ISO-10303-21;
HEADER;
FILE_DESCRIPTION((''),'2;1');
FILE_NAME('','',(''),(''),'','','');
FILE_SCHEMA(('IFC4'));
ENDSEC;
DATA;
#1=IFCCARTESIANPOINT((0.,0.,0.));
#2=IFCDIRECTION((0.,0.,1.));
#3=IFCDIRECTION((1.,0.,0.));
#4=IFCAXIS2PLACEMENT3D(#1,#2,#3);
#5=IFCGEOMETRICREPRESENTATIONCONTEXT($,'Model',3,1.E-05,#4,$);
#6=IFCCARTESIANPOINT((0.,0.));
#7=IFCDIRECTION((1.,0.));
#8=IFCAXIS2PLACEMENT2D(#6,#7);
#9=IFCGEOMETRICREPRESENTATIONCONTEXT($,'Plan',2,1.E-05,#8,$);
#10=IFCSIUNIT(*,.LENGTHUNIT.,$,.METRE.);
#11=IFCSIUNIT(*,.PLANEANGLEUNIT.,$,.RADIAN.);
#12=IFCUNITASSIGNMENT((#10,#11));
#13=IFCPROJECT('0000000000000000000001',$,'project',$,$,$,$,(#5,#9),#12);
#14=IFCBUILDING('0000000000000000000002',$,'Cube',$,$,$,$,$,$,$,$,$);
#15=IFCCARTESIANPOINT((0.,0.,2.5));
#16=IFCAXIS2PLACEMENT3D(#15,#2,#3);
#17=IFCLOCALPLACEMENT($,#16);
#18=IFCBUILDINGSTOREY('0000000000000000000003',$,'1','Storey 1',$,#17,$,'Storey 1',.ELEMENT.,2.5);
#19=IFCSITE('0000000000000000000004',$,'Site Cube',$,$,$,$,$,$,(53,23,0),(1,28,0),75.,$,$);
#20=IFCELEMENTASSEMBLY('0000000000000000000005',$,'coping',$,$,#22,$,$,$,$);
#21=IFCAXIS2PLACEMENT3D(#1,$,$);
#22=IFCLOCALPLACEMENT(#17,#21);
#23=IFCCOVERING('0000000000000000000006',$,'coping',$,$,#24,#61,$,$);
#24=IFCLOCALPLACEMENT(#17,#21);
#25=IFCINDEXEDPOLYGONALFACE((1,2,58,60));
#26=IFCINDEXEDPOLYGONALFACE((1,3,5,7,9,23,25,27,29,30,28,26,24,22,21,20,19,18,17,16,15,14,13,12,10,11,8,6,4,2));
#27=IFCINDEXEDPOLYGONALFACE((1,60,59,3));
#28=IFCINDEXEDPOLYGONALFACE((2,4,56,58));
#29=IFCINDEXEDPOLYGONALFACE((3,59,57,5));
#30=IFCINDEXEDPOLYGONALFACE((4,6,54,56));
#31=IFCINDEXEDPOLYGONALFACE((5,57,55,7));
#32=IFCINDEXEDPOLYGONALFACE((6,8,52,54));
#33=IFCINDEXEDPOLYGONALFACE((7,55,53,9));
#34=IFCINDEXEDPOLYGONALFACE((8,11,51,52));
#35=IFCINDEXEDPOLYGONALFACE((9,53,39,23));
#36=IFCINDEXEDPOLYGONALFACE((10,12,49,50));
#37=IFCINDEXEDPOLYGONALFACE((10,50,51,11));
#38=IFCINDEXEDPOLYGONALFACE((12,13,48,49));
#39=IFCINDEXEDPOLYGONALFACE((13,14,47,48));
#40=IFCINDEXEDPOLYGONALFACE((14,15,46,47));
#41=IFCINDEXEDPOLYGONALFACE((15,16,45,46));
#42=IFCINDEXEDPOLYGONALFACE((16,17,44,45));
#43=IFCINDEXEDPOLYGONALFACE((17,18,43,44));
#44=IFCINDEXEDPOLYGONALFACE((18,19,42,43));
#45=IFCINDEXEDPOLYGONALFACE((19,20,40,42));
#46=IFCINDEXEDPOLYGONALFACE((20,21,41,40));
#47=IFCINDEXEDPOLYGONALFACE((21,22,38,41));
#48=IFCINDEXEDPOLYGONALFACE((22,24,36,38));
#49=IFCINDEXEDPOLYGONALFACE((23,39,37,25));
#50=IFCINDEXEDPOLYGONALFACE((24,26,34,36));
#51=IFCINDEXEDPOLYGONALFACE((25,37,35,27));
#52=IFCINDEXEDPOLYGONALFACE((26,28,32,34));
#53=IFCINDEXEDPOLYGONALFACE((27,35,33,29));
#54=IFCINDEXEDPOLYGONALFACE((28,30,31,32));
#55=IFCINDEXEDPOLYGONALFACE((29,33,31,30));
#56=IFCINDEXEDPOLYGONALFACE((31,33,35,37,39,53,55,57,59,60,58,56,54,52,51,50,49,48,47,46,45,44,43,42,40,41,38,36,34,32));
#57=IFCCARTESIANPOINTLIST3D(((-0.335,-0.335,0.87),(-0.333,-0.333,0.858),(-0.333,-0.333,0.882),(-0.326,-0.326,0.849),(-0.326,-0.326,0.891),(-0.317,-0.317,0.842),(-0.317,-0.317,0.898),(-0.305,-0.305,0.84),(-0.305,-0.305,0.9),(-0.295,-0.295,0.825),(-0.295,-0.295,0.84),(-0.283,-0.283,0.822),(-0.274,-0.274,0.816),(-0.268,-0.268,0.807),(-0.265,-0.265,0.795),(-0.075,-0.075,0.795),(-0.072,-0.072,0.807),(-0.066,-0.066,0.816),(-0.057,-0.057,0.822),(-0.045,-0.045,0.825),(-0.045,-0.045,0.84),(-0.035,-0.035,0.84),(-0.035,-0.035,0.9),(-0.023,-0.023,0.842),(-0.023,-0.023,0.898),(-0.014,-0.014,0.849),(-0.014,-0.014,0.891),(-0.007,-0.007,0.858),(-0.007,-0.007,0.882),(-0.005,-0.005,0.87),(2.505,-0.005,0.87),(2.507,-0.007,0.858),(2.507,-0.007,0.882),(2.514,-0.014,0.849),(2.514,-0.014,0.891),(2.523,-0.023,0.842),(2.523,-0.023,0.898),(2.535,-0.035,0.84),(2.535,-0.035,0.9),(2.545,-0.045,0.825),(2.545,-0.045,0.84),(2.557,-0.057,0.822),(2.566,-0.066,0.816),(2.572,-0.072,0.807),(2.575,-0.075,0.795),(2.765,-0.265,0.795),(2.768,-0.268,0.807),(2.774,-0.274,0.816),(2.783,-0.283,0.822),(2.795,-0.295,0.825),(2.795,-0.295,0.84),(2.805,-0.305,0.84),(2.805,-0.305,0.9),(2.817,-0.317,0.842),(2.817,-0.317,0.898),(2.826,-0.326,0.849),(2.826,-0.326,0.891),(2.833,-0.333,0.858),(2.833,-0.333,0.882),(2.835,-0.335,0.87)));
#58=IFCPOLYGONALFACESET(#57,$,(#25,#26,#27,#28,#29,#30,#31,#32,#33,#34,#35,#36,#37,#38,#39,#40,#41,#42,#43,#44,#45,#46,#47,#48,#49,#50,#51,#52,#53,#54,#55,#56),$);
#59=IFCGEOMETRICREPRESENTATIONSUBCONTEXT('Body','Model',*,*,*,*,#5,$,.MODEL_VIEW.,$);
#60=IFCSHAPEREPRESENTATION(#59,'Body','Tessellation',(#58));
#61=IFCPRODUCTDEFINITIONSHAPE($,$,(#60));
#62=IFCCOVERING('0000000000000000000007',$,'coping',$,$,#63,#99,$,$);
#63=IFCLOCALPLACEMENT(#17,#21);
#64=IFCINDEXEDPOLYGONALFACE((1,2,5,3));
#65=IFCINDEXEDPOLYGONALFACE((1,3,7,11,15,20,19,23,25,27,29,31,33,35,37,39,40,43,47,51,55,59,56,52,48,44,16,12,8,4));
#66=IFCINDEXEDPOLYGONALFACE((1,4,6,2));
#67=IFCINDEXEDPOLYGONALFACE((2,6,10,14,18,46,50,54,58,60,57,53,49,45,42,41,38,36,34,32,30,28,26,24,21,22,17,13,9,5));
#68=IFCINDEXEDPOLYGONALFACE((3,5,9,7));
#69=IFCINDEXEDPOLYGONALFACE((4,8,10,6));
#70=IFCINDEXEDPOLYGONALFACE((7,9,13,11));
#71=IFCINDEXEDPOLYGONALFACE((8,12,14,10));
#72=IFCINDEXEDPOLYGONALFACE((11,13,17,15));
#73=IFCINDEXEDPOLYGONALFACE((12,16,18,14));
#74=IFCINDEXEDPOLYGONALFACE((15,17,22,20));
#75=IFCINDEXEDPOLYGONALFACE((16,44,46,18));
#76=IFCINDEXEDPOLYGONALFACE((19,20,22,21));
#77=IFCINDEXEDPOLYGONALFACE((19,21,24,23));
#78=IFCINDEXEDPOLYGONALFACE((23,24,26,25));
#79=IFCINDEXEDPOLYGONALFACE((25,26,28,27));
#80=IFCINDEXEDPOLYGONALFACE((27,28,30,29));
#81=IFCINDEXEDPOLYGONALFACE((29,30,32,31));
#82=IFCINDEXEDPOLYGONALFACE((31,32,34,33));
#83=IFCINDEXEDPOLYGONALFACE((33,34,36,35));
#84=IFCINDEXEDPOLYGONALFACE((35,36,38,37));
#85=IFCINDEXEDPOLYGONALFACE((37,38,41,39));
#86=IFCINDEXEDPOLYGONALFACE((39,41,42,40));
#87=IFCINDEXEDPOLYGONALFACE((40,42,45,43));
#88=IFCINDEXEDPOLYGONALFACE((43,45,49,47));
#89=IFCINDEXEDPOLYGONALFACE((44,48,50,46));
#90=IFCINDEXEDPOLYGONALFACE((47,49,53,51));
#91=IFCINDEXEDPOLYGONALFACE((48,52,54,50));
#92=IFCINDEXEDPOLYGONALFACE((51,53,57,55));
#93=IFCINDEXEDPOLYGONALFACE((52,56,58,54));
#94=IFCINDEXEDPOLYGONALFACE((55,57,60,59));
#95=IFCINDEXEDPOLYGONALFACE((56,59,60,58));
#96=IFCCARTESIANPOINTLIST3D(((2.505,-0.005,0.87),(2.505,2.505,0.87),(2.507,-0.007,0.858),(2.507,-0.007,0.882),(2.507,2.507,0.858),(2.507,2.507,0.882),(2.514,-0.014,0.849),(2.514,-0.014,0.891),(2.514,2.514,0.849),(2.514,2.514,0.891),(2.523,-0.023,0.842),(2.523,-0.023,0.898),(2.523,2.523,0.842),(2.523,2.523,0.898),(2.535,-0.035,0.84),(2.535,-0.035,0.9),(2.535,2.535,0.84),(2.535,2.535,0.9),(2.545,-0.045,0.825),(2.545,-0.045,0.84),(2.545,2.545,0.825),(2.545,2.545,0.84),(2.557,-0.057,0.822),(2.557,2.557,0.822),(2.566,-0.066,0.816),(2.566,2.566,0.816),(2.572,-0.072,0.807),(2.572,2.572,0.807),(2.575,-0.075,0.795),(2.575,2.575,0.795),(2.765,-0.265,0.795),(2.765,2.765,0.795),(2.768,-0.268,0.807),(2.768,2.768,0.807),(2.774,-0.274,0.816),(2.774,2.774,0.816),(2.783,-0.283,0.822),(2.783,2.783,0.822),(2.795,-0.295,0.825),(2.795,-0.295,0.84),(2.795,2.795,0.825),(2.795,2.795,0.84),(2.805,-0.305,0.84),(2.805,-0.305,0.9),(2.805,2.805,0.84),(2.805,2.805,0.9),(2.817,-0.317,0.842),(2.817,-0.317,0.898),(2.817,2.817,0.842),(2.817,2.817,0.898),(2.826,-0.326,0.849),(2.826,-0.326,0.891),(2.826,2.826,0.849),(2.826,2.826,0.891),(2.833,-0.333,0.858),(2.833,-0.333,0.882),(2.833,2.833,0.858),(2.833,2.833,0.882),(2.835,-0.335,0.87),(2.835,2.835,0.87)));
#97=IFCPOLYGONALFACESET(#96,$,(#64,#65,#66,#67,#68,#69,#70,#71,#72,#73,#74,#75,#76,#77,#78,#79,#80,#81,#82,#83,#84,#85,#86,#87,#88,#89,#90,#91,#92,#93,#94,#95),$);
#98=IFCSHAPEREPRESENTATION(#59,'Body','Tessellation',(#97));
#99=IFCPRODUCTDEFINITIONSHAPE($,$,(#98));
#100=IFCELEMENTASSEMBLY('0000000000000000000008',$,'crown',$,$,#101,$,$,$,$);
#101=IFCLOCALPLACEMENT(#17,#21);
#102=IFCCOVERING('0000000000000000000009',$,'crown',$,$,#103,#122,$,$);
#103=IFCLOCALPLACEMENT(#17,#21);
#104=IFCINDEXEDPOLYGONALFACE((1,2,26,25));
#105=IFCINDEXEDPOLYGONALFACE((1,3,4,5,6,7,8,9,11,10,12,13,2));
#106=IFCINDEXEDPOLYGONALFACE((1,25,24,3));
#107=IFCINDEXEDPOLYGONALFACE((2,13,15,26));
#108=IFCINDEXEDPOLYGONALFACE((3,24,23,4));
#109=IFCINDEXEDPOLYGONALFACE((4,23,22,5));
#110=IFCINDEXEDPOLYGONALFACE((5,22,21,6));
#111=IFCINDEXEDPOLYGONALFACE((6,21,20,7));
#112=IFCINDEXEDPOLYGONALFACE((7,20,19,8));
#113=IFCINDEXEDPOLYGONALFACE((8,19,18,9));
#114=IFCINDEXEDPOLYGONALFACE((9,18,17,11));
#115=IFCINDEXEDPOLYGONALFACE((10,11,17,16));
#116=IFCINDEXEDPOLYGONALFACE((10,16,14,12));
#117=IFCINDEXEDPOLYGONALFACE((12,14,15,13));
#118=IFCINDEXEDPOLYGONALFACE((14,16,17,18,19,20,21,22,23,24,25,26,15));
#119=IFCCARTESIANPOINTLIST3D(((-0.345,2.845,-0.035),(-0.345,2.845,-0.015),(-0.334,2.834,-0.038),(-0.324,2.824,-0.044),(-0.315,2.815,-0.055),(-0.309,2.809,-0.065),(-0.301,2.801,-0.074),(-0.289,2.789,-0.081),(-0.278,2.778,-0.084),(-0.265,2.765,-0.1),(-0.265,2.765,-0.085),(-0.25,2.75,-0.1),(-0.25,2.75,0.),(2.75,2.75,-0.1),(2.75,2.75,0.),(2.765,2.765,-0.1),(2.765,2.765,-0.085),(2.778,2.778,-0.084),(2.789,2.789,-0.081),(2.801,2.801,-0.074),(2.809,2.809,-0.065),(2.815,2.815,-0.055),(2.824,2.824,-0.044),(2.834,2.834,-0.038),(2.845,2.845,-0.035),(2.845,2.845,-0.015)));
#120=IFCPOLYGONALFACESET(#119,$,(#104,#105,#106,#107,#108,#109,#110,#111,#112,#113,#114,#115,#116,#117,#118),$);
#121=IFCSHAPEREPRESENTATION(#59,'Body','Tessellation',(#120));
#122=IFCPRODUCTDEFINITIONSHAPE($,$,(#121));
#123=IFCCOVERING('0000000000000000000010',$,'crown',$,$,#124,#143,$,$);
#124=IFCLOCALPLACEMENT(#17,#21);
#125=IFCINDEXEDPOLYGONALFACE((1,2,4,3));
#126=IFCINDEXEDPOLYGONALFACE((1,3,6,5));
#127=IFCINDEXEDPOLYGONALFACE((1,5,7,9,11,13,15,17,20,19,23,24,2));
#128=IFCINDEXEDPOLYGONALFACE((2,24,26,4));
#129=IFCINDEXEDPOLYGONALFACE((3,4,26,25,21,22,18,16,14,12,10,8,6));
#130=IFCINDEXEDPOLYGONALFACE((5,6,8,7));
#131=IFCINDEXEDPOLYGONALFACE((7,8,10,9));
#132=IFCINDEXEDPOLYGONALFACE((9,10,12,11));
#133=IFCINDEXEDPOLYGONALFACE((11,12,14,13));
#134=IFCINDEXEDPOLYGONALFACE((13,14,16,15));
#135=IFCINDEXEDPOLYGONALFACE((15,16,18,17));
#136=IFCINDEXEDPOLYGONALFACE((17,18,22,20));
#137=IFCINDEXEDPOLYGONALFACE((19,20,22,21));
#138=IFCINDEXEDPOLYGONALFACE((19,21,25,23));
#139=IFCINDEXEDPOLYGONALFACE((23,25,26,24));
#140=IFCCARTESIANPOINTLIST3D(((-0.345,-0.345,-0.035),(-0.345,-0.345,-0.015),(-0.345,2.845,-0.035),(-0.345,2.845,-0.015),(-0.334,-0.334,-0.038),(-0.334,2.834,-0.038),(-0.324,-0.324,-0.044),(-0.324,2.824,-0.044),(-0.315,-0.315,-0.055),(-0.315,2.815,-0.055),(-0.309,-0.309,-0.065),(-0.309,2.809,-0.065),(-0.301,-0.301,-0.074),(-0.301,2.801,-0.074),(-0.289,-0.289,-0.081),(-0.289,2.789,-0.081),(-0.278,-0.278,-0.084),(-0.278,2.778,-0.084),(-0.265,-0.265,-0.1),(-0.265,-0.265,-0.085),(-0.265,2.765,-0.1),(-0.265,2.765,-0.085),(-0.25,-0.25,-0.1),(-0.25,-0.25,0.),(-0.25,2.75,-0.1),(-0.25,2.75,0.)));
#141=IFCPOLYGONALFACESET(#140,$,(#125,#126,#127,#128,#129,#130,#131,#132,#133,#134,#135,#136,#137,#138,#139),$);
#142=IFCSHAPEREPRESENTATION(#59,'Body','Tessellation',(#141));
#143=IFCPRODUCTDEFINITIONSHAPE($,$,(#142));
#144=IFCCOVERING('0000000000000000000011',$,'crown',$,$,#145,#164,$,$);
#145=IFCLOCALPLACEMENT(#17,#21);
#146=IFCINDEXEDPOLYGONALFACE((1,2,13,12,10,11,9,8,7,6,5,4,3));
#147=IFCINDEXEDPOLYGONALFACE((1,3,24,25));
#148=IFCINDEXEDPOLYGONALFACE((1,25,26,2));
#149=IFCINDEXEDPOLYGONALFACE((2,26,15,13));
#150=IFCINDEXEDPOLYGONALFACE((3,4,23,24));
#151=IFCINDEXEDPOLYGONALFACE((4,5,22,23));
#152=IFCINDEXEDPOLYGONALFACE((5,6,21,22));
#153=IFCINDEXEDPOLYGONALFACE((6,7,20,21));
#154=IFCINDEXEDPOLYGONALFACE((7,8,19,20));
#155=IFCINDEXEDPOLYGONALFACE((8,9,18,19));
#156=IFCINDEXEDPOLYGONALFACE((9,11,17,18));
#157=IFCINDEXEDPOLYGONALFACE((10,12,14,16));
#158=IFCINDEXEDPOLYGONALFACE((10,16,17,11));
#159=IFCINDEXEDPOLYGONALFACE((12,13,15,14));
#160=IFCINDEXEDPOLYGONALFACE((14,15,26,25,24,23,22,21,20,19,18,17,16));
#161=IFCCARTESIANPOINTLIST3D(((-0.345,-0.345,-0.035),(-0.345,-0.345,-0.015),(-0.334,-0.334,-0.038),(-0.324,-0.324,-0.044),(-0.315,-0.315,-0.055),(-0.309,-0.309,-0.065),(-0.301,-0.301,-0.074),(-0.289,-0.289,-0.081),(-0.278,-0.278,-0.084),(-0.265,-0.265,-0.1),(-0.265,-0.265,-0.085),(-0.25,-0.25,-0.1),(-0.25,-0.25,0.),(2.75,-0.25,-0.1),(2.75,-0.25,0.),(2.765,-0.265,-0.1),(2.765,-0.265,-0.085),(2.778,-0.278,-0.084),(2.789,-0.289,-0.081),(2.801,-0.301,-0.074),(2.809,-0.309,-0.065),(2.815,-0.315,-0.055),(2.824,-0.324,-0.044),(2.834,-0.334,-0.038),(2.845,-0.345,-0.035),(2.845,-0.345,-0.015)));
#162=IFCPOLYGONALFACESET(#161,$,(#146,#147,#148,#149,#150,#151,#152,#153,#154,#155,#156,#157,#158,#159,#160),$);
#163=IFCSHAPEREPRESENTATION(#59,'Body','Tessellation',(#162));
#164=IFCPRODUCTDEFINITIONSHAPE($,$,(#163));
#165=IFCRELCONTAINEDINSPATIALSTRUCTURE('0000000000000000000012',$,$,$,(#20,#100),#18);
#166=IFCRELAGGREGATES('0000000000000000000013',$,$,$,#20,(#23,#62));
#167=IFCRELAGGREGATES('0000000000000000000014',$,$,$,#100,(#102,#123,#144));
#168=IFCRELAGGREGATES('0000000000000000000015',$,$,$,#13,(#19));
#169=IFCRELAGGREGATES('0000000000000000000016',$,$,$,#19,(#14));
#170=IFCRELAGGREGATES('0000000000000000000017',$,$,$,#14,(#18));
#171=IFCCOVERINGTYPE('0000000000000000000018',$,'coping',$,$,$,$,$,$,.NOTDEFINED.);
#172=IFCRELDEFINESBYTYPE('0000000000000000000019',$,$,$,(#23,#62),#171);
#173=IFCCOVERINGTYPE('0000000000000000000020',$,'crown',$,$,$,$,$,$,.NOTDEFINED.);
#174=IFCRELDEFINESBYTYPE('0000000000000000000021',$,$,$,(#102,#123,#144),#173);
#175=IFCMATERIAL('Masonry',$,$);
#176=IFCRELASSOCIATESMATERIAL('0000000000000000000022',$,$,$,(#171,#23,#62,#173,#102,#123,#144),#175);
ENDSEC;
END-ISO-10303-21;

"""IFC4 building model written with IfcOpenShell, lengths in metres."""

from ifc_helpers import new_model, si_unit, frame, origin_with_axes, origin_2d_with_axis, place, context, subcontext, project, spatial, polyline, outline, extrude, clip, halfspace, material, material_profile, profile_set, profile_usage, type_object, element, aggregate, save


model = new_model("IFC4")

# Units and contexts
model_context = context("Model", 3, precision=1e-05, world=origin_with_axes())
plan_context = context("Plan", 2, precision=1e-05, world=origin_2d_with_axis())
body_context = subcontext(model_context, "Body", "Model", "MODEL_VIEW")
ifc_project = project(units=[si_unit("LENGTHUNIT", "METRE"), si_unit("PLANEANGLEUNIT", "RADIAN")], contexts=[model_context, plan_context])

# Site, building, storey
site = spatial("IfcSite", under=ifc_project, Name="Site Cube", RefLatitude=(53, 23, 0), RefLongitude=(1, 28, 0), RefElevation=75.0)
building = spatial("IfcBuilding", under=site, Name="Cube")
storey_placement = place(None, frame((0.0, 0.0, 2.5), z_axis=(0.0, 0.0, 1.0), x_axis=(1.0, 0.0, 0.0)))
storey = spatial("IfcBuildingStorey", under=building, at=storey_placement, Name="1", Description="Storey 1", LongName="Storey 1", CompositionType="ELEMENT", Elevation=2.5)

# Shared definitions
ifc_material_1 = material(Name="Masonry")

# Element assemblies, coverings
assembly_1_placement = place(storey_placement, frame((0.0, 0.0, -2.5), z_axis=(0.0, 0.0, 1.0), x_axis=(1.0, 0.0, 0.0)))
assembly_1 = element("IfcElementAssembly", 1, at=assembly_1_placement, inside=storey, Name="coping")
ifc_material_profile_1 = material_profile(ifc_material_1, outline(polyline([(0.265, 0.795), (0.268, 0.807), (0.274, 0.816), (0.283, 0.822), (0.295, 0.825), (0.295, 0.84), (0.305, 0.84), (0.317, 0.842), (0.326, 0.849), (0.333, 0.858), (0.335, 0.87), (0.333, 0.882), (0.326, 0.891), (0.317, 0.898), (0.305, 0.9), (0.035, 0.9), (0.023, 0.898), (0.014, 0.891), (0.007, 0.882), (0.005, 0.87), (0.007, 0.858), (0.014, 0.849), (0.023, 0.842), (0.035, 0.84), (0.045, 0.84), (0.045, 0.825), (0.057, 0.822), (0.066, 0.816), (0.072, 0.807), (0.075, 0.795), (0.265, 0.795)])))
ifc_profile_set_1 = profile_set([ifc_material_profile_1])
covering_type_1 = type_object("IfcCoveringType", Name="coping", PredefinedType="NOTDEFINED", material=ifc_profile_set_1)
ifc_profile_usage_1 = profile_usage(ifc_profile_set_1)
covering_1_placement = place(assembly_1_placement, frame((3.5, 0.0, 2.5), z_axis=(-1.0, 0.0, 0.0), x_axis=(0.0, -1.0, 0.0)))
covering_1 = element("IfcCovering", 2, at=covering_1_placement, type_object=covering_type_1, material=ifc_profile_usage_1, Name="coping", context=body_context, shape_type="Clipping", body=[
    clip(clip(extrude(outline(polyline([(0.265, 0.795), (0.268, 0.807), (0.274, 0.816), (0.283, 0.822), (0.295, 0.825), (0.295, 0.84), (0.305, 0.84), (0.317, 0.842), (0.326, 0.849), (0.333, 0.858), (0.335, 0.87), (0.333, 0.882), (0.326, 0.891), (0.317, 0.898), (0.305, 0.9), (0.035, 0.9), (0.023, 0.898), (0.014, 0.891), (0.007, 0.882), (0.005, 0.87), (0.007, 0.858), (0.014, 0.849), (0.023, 0.842), (0.035, 0.84), (0.045, 0.84), (0.045, 0.825), (0.057, 0.822), (0.066, 0.816), (0.072, 0.807), (0.075, 0.795), (0.265, 0.795)])), origin_with_axes(), (0.0, 0.0, 1.0), 4.5), halfspace(frame((0.0, -2.5, 1.0), z_axis=(-0.707107, 0.0, -0.707107), x_axis=(0.707107, 0.0, -0.707107)), False)), halfspace(frame((0.0, -2.5, 3.5), z_axis=(-0.707107, 0.0, 0.707107), x_axis=(0.707107, 0.0, 0.707107)), False)),
])
ifc_profile_usage_2 = profile_usage(ifc_profile_set_1)
covering_2_placement = place(assembly_1_placement, frame((2.5, 3.5, 2.5), z_axis=(0.0, -1.0, 0.0), x_axis=(1.0, 0.0, 0.0)))
covering_2 = element("IfcCovering", 3, at=covering_2_placement, type_object=covering_type_1, material=ifc_profile_usage_2, Name="coping", context=body_context, shape_type="Clipping", body=[
    clip(clip(extrude(outline(polyline([(0.265, 0.795), (0.268, 0.807), (0.274, 0.816), (0.283, 0.822), (0.295, 0.825), (0.295, 0.84), (0.305, 0.84), (0.317, 0.842), (0.326, 0.849), (0.333, 0.858), (0.335, 0.87), (0.333, 0.882), (0.326, 0.891), (0.317, 0.898), (0.305, 0.9), (0.035, 0.9), (0.023, 0.898), (0.014, 0.891), (0.007, 0.882), (0.005, 0.87), (0.007, 0.858), (0.014, 0.849), (0.023, 0.842), (0.035, 0.84), (0.045, 0.84), (0.045, 0.825), (0.057, 0.822), (0.066, 0.816), (0.072, 0.807), (0.075, 0.795), (0.265, 0.795)])), origin_with_axes(), (0.0, 0.0, 1.0), 4.5), halfspace(frame((0.0, -2.5, 1.0), z_axis=(-0.707107, 0.0, -0.707107), x_axis=(0.707107, 0.0, -0.707107)), False)), halfspace(frame((0.0, -2.5, 3.5), z_axis=(-0.707107, 0.0, 0.707107), x_axis=(0.707107, 0.0, 0.707107)), False)),
])
aggregate(assembly_1, [covering_1, covering_2])
assembly_2_placement = place(storey_placement, frame((0.0, 0.0, -2.5), z_axis=(0.0, 0.0, 1.0), x_axis=(1.0, 0.0, 0.0)))
assembly_2 = element("IfcElementAssembly", 4, at=assembly_2_placement, inside=storey, Name="crown")
ifc_material_profile_2 = material_profile(ifc_material_1, outline(polyline([(0.25, -0.1), (0.265, -0.1), (0.265, -0.085), (0.278, -0.084), (0.289, -0.081), (0.301, -0.074), (0.309, -0.065), (0.315, -0.055), (0.324, -0.044), (0.334, -0.038), (0.345, -0.035), (0.345, -0.015), (0.25, 0.0), (0.25, -0.1)])))
ifc_profile_set_2 = profile_set([ifc_material_profile_2])
ifc_profile_usage_3 = profile_usage(ifc_profile_set_2)
covering_type_2 = type_object("IfcCoveringType", Name="crown", PredefinedType="NOTDEFINED", material=ifc_profile_set_2)
covering_3_placement = place(assembly_2_placement, frame((-1.0, 2.5, 2.5), z_axis=(1.0, 0.0, 0.0), x_axis=(0.0, 1.0, 0.0)))
covering_3 = element("IfcCovering", 5, at=covering_3_placement, type_object=covering_type_2, material=ifc_profile_usage_3, Name="crown", context=body_context, shape_type="Clipping", body=[
    clip(clip(extrude(outline(polyline([(0.25, -0.1), (0.265, -0.1), (0.265, -0.085), (0.278, -0.084), (0.289, -0.081), (0.301, -0.074), (0.309, -0.065), (0.315, -0.055), (0.324, -0.044), (0.334, -0.038), (0.345, -0.035), (0.345, -0.015), (0.25, 0.0), (0.25, -0.1)])), origin_with_axes(), (0.0, 0.0, 1.0), 4.5), halfspace(frame((0.0, -2.5, 1.0), z_axis=(-0.707107, 0.0, -0.707107), x_axis=(0.707107, 0.0, -0.707107)), False)), halfspace(frame((0.0, -2.5, 3.5), z_axis=(-0.707107, 0.0, 0.707107), x_axis=(0.707107, 0.0, 0.707107)), False)),
])
ifc_profile_usage_4 = profile_usage(ifc_profile_set_2)
covering_4_placement = place(assembly_2_placement, frame((0.0, -1.0, 2.5), z_axis=(0.0, 1.0, 0.0), x_axis=(-1.0, 0.0, 0.0)))
covering_4 = element("IfcCovering", 6, at=covering_4_placement, type_object=covering_type_2, material=ifc_profile_usage_4, Name="crown", context=body_context, shape_type="Clipping", body=[
    clip(clip(extrude(outline(polyline([(0.25, -0.1), (0.265, -0.1), (0.265, -0.085), (0.278, -0.084), (0.289, -0.081), (0.301, -0.074), (0.309, -0.065), (0.315, -0.055), (0.324, -0.044), (0.334, -0.038), (0.345, -0.035), (0.345, -0.015), (0.25, 0.0), (0.25, -0.1)])), origin_with_axes(), (0.0, 0.0, 1.0), 4.5), halfspace(frame((0.0, -2.5, 1.0), z_axis=(-0.707107, 0.0, -0.707107), x_axis=(0.707107, 0.0, -0.707107)), False)), halfspace(frame((0.0, -2.5, 3.5), z_axis=(-0.707107, 0.0, 0.707107), x_axis=(0.707107, 0.0, 0.707107)), False)),
])
ifc_profile_usage_5 = profile_usage(ifc_profile_set_2)
covering_5_placement = place(assembly_2_placement, frame((3.5, 0.0, 2.5), z_axis=(-1.0, 0.0, 0.0), x_axis=(0.0, -1.0, 0.0)))
covering_5 = element("IfcCovering", 7, at=covering_5_placement, type_object=covering_type_2, material=ifc_profile_usage_5, Name="crown", context=body_context, shape_type="Clipping", body=[
    clip(clip(extrude(outline(polyline([(0.25, -0.1), (0.265, -0.1), (0.265, -0.085), (0.278, -0.084), (0.289, -0.081), (0.301, -0.074), (0.309, -0.065), (0.315, -0.055), (0.324, -0.044), (0.334, -0.038), (0.345, -0.035), (0.345, -0.015), (0.25, 0.0), (0.25, -0.1)])), origin_with_axes(), (0.0, 0.0, 1.0), 4.5), halfspace(frame((0.0, -2.5, 1.0), z_axis=(-0.707107, 0.0, -0.707107), x_axis=(0.707107, 0.0, -0.707107)), False)), halfspace(frame((0.0, -2.5, 3.5), z_axis=(-0.707107, 0.0, 0.707107), x_axis=(0.707107, 0.0, 0.707107)), False)),
])
aggregate(assembly_2, [covering_3, covering_4, covering_5])

save(model, "model.ifc")
